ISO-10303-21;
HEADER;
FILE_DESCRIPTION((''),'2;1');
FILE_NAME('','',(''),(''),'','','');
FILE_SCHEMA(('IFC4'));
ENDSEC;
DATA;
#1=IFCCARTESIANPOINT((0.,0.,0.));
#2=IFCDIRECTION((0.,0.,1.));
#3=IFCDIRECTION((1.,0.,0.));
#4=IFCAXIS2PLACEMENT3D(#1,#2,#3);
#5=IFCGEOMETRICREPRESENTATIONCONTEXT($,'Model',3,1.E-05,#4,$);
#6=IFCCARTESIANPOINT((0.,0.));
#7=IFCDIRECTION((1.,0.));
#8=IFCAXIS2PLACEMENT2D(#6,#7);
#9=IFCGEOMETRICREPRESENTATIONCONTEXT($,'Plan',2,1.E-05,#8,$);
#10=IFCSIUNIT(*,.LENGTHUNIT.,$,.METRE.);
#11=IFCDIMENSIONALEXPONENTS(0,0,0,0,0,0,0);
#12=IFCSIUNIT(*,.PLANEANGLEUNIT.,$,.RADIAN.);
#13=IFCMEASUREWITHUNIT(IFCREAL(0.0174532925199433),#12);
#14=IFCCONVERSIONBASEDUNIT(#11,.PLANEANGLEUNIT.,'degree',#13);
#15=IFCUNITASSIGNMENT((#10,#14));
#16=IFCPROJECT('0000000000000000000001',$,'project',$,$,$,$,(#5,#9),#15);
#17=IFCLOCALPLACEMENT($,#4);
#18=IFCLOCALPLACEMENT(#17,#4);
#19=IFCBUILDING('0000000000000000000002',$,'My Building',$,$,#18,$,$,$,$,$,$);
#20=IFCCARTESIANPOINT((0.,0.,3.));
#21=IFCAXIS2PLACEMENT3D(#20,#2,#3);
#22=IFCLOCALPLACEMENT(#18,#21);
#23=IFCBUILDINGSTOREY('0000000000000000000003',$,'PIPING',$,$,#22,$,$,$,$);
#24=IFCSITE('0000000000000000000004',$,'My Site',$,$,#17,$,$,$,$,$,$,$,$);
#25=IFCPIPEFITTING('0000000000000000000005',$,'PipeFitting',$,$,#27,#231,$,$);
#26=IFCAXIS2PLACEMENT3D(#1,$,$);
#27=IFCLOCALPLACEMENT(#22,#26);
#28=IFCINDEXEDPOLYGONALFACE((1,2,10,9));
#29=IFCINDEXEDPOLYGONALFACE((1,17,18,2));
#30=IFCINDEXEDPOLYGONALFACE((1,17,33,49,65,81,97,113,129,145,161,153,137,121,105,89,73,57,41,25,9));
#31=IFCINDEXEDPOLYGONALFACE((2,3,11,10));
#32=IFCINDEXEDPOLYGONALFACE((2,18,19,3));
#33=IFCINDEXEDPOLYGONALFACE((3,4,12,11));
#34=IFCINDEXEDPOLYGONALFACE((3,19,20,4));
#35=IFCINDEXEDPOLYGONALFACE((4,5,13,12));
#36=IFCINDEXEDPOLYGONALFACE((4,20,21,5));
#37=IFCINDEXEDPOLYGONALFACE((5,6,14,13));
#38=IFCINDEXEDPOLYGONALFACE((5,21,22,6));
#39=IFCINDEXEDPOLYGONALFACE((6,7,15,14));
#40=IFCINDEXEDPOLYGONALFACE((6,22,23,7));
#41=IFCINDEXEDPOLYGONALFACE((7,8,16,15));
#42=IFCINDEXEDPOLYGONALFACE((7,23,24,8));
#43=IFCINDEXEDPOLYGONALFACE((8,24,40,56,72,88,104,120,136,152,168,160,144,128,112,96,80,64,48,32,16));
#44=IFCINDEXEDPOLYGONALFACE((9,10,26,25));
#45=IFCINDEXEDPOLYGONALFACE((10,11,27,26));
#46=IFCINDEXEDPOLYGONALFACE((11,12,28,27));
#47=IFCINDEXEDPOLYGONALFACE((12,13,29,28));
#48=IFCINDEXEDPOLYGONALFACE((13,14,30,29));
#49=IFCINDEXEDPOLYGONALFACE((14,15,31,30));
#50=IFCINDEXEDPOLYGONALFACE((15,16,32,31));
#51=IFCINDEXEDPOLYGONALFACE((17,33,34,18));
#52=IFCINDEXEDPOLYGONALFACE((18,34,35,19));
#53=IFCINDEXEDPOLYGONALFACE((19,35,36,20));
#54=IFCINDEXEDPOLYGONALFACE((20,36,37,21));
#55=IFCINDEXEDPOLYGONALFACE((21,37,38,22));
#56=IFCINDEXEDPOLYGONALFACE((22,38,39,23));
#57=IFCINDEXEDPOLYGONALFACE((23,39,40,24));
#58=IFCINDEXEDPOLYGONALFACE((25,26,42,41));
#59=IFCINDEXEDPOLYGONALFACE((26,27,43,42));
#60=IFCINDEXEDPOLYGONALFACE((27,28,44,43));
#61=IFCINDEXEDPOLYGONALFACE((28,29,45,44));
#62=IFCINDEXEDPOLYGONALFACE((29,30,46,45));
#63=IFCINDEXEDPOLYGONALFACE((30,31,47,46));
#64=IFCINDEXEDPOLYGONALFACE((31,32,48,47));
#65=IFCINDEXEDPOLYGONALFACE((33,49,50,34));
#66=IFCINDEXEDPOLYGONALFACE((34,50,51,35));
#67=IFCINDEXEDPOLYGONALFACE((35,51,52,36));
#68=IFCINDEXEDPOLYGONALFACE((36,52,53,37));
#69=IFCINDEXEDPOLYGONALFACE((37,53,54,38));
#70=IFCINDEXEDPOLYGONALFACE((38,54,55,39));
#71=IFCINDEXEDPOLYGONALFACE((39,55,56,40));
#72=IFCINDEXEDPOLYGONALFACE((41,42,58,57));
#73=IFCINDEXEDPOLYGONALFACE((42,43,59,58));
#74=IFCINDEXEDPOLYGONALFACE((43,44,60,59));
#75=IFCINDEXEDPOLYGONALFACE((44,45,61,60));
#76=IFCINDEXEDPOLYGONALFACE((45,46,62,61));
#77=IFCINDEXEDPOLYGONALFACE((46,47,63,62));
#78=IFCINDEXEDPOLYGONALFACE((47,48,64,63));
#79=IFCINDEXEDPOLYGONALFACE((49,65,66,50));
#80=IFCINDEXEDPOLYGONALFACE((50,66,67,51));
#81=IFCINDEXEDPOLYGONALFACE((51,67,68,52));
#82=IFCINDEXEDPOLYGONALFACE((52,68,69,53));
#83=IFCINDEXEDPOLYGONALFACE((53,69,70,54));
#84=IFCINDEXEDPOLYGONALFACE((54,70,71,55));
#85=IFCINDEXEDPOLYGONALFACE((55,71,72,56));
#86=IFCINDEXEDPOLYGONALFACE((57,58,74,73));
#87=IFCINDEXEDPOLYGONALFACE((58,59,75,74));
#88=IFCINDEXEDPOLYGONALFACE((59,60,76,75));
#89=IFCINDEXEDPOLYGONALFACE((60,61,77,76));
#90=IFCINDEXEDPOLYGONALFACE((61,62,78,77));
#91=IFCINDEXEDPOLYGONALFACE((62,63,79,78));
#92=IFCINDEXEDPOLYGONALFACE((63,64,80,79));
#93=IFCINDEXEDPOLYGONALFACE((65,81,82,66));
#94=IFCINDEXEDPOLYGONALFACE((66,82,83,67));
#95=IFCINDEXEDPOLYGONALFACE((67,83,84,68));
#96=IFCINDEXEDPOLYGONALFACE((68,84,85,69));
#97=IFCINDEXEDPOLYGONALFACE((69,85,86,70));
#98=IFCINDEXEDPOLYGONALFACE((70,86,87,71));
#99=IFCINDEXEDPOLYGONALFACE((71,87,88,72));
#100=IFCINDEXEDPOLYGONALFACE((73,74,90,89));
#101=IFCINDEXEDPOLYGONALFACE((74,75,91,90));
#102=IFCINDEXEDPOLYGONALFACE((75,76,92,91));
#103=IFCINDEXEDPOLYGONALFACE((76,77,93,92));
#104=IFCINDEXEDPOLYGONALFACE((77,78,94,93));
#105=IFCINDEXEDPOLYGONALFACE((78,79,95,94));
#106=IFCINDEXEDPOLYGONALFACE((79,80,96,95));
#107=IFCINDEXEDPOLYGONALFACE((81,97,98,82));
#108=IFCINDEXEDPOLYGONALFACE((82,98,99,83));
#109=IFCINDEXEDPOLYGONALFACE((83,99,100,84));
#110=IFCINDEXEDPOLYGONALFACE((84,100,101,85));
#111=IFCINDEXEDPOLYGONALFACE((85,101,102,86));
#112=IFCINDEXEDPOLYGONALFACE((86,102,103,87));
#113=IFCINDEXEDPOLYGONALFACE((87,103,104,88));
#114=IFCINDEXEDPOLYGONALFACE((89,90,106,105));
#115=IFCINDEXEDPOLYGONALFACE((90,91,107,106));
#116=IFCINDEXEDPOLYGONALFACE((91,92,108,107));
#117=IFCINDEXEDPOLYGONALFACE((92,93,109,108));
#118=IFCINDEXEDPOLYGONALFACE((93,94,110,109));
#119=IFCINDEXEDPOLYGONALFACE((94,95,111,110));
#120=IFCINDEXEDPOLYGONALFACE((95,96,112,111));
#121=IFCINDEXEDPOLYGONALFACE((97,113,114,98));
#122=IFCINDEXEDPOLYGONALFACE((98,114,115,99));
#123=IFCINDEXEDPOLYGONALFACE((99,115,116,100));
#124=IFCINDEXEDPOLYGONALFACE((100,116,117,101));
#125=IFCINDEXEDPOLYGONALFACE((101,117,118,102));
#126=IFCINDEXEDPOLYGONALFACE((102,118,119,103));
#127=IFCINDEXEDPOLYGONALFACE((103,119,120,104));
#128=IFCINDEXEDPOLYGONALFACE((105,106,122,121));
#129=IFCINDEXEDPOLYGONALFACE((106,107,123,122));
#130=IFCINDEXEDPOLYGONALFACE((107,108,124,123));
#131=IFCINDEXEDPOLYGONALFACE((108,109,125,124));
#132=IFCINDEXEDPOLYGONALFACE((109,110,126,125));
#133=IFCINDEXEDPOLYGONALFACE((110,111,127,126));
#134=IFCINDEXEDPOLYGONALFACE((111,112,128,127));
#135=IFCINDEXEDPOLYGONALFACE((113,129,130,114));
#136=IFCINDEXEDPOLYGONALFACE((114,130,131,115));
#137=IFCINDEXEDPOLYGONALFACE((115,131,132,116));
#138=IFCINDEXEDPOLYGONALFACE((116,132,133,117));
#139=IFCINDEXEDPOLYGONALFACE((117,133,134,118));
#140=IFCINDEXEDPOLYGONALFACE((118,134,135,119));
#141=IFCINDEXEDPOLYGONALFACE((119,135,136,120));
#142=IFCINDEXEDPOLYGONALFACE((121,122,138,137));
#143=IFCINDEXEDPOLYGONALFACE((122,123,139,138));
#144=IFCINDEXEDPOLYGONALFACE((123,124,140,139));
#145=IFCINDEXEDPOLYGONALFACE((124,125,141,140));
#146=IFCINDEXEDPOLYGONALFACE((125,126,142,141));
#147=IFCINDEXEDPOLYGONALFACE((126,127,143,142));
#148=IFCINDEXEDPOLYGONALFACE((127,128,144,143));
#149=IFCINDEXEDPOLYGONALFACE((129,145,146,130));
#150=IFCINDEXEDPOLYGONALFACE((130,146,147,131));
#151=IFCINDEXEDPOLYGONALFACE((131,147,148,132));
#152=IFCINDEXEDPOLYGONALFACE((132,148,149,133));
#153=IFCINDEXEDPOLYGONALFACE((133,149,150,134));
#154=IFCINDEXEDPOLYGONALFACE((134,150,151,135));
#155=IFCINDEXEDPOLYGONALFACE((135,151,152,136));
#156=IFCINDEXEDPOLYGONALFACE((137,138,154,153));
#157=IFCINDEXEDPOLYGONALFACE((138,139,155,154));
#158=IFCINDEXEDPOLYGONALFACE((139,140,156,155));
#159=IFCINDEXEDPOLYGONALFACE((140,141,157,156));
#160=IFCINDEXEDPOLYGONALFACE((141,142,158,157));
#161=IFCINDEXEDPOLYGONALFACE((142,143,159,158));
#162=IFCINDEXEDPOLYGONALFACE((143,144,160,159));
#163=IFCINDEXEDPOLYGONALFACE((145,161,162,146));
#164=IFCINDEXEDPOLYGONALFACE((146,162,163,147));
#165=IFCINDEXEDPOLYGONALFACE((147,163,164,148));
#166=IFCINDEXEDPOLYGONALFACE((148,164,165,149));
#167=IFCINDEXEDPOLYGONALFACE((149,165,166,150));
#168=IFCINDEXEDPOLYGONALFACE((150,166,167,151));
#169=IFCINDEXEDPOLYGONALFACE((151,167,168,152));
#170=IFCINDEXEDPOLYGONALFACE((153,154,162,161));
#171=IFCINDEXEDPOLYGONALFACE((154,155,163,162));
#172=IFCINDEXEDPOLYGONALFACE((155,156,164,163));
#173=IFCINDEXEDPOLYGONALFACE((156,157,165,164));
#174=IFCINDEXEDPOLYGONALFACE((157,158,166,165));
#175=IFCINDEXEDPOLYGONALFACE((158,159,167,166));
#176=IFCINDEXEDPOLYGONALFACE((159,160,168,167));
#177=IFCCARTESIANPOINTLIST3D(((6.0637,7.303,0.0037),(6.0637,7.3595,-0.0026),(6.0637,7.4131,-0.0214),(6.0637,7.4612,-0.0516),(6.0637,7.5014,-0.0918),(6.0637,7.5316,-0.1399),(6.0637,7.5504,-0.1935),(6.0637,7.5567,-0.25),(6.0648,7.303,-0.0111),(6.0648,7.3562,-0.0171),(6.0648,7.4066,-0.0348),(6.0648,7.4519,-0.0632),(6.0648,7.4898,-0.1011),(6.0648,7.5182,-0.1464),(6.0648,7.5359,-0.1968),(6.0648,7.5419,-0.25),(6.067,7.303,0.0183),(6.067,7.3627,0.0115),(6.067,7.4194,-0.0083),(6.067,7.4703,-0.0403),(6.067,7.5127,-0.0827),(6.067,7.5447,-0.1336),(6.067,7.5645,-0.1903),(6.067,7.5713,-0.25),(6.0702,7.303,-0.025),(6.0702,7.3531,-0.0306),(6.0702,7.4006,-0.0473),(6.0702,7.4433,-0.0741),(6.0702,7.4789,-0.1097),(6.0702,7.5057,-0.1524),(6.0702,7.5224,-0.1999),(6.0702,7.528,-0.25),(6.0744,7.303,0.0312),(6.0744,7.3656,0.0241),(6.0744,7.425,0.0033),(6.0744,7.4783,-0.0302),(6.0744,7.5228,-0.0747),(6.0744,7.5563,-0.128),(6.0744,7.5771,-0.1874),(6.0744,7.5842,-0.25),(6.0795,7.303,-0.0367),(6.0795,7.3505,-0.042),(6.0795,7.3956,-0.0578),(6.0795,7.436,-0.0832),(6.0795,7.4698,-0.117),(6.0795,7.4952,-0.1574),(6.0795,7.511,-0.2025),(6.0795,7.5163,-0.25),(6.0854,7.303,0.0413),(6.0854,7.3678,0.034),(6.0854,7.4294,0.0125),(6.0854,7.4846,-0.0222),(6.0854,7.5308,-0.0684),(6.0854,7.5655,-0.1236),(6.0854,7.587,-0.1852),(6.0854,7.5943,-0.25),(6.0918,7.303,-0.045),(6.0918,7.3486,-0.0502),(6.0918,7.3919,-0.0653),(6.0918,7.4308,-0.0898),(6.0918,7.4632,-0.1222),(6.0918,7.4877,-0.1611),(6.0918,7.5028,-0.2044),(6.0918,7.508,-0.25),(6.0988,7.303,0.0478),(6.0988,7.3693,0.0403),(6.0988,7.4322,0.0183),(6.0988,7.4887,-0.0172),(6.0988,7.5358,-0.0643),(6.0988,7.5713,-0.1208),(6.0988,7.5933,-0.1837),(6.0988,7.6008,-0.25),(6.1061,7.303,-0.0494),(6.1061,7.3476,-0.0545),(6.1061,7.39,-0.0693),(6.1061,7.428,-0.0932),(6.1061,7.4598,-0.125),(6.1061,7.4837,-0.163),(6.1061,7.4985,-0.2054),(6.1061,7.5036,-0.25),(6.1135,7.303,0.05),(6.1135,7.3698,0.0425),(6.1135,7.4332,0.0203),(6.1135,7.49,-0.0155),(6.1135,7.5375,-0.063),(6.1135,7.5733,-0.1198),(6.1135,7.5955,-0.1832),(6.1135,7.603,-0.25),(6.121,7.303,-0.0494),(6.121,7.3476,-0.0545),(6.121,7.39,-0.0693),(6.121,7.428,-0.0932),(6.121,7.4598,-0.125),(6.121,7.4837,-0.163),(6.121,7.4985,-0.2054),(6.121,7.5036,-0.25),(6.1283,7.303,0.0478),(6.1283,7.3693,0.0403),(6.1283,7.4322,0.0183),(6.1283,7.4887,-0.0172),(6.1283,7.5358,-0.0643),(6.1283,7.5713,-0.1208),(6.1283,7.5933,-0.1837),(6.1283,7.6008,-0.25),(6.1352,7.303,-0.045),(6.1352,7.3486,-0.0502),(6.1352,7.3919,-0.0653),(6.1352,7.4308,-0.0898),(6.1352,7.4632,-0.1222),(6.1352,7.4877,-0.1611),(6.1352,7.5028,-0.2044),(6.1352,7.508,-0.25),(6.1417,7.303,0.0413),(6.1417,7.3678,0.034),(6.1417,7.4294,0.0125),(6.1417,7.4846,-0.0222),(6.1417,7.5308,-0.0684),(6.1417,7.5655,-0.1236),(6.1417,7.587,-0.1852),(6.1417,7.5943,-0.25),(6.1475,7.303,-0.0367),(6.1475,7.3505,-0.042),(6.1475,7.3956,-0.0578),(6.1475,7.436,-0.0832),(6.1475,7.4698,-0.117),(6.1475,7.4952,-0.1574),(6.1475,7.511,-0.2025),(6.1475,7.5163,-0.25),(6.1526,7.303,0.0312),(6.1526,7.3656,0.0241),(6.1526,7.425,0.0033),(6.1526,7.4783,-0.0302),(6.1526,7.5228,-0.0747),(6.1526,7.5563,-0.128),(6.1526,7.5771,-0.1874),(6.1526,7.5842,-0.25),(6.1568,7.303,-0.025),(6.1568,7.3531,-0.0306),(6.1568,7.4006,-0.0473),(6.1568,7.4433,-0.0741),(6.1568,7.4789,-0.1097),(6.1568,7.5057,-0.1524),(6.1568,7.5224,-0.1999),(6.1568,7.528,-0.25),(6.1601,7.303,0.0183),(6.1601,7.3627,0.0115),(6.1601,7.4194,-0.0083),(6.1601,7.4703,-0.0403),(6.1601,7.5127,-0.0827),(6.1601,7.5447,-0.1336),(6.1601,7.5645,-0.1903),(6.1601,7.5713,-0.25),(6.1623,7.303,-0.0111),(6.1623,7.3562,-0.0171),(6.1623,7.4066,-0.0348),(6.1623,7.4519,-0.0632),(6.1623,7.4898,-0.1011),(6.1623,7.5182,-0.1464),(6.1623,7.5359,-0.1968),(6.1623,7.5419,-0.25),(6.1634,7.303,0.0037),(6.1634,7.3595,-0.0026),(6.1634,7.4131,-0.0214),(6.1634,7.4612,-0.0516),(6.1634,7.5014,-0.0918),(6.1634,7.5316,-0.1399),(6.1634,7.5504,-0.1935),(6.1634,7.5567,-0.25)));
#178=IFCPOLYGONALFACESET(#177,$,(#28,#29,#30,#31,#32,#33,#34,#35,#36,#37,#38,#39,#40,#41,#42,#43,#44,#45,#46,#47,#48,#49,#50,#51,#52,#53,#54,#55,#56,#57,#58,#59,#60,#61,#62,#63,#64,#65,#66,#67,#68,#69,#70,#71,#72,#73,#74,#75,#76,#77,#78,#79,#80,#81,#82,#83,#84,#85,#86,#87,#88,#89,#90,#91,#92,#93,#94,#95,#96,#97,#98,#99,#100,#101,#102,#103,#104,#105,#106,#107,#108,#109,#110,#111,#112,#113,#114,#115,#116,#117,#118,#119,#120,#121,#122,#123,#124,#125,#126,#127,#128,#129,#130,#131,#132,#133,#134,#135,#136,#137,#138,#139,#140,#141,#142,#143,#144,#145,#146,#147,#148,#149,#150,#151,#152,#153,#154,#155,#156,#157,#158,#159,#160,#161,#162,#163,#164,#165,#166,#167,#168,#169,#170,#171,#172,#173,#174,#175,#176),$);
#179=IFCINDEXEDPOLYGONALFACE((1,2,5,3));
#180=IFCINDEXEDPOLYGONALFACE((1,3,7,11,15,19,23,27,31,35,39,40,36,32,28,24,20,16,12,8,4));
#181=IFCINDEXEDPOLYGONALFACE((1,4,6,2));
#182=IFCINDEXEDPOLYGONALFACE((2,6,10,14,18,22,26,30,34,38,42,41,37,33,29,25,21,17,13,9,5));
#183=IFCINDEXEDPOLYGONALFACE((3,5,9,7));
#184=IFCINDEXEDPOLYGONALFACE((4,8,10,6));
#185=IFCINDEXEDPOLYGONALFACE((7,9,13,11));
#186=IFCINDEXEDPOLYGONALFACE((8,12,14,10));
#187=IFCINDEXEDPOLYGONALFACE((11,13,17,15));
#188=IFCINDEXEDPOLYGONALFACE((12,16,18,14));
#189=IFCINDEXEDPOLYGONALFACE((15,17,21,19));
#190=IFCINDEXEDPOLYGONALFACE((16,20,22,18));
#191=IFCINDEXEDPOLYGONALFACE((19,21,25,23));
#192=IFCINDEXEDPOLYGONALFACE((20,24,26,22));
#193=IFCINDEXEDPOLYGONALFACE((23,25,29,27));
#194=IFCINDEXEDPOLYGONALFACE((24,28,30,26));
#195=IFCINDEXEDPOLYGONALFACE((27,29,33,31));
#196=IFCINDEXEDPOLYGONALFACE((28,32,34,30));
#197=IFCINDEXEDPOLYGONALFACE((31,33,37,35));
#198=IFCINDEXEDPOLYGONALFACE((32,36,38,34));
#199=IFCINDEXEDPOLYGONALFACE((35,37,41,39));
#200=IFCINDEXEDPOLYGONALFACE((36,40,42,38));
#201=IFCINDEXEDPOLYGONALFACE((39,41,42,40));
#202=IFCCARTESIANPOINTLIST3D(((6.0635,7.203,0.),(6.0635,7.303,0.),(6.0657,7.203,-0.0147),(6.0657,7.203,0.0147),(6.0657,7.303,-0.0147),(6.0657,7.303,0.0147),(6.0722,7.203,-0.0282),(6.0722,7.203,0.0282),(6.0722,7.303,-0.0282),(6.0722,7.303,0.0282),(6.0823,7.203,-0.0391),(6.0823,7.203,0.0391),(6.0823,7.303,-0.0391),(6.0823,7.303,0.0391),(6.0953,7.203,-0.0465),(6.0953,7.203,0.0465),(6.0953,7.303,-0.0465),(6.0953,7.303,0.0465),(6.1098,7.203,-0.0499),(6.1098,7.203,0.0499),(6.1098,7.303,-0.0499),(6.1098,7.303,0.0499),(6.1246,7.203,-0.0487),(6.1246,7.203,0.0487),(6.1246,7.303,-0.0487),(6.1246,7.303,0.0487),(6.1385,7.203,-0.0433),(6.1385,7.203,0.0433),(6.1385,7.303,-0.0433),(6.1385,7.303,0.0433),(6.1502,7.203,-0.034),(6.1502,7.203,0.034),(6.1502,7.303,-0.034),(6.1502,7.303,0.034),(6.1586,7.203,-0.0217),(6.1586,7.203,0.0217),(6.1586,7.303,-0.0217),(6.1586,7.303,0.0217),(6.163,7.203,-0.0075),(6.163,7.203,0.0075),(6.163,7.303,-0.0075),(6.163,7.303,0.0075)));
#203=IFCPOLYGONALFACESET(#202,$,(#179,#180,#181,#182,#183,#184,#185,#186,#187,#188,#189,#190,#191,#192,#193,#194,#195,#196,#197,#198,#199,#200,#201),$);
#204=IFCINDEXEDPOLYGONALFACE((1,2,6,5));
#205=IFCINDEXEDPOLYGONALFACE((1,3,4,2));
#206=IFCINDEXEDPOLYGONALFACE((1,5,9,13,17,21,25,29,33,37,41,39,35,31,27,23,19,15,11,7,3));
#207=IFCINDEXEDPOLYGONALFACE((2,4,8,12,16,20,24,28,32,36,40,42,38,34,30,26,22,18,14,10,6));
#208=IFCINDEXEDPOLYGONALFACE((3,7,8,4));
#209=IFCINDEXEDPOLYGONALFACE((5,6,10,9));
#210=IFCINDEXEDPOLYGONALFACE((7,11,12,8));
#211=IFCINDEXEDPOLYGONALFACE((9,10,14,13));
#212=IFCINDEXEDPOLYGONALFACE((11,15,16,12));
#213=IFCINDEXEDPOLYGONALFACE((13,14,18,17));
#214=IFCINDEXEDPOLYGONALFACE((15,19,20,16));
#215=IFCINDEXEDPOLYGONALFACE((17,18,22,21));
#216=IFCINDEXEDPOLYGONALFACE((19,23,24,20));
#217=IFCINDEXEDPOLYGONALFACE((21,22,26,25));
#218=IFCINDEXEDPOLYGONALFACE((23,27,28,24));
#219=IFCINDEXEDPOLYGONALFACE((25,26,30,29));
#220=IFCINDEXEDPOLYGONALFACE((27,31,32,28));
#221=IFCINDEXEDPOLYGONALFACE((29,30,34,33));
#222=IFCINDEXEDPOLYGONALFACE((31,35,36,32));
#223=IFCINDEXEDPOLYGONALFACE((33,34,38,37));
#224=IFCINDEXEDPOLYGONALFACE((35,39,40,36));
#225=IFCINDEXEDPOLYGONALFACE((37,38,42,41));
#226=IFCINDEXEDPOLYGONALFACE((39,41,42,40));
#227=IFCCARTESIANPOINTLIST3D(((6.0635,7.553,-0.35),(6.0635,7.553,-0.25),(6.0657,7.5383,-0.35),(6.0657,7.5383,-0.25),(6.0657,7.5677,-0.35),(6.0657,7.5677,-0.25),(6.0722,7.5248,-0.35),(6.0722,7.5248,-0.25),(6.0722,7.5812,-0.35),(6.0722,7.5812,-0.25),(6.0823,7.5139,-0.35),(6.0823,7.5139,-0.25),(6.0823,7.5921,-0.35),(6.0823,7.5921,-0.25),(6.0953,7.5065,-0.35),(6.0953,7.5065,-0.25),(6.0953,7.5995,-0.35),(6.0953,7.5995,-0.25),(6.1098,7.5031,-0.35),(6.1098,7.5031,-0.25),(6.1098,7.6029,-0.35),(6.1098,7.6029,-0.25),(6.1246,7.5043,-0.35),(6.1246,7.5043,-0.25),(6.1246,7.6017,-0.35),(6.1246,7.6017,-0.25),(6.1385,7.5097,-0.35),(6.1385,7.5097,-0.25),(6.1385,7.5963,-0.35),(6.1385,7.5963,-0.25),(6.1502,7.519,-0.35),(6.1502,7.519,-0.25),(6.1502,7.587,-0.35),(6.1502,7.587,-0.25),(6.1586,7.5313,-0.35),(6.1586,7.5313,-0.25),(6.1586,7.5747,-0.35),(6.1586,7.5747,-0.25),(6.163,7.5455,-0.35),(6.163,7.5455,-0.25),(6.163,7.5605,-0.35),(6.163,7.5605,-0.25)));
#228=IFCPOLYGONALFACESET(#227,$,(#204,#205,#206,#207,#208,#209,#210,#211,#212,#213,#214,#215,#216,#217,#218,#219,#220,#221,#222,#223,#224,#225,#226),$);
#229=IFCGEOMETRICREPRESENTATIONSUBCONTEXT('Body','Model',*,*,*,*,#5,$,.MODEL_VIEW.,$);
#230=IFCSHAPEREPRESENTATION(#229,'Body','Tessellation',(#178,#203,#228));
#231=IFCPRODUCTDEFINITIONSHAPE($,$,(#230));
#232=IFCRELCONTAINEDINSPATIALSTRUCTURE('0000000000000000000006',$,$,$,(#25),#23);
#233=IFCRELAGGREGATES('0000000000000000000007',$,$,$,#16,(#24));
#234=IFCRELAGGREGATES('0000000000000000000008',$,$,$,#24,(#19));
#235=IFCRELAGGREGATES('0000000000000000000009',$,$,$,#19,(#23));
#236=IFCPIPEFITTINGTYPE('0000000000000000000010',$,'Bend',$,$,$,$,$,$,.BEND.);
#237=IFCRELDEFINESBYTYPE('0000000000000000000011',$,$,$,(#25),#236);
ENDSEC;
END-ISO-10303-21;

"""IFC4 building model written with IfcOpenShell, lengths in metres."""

from ifc_helpers import new_model, entity, si_unit, converted_unit, frame, origin_with_axes, origin_2d_with_axis, place, context, subcontext, project, spatial, circle, extrude, source, transform, mapped, type_object, type_shapes, element, save


model = new_model("IFC4")

# Units and contexts
model_context = context("Model", 3, precision=1e-05, world=origin_with_axes())
plan_context = context("Plan", 2, precision=1e-05, world=origin_2d_with_axis())
body_context = subcontext(model_context, "Body", "Model", "MODEL_VIEW")
ifc_project = project(units=[si_unit("LENGTHUNIT", "METRE"), converted_unit("PLANEANGLEUNIT", "degree", entity("IfcReal", 0.0174532925199433), si_unit("PLANEANGLEUNIT", "RADIAN"), dimensions=[0, 0, 0, 0, 0, 0, 0])], contexts=[model_context, plan_context])

# Site, building, storey
site_placement = place(None, origin_with_axes())
site = spatial("IfcSite", under=ifc_project, at=site_placement, Name="My Site")
building_placement = place(site_placement, origin_with_axes())
building = spatial("IfcBuilding", under=site, at=building_placement, Name="My Building")
storey_placement = place(building_placement, frame((0.0, 0.0, 3.0), z_axis=(0.0, 0.0, 1.0), x_axis=(1.0, 0.0, 0.0)))
storey = spatial("IfcBuildingStorey", under=building, at=storey_placement, Name="PIPING")

# Shared definitions
pipe_fitting_type = type_object("IfcPipeFittingType", Name="Bend", PredefinedType="BEND")
shared_shape = source(origin_with_axes(), body_context, "Body", "SolidModel", [
    entity("IfcSweptDiskSolid", entity("IfcIndexedPolyCurve", entity("IfcCartesianPointList3D", [[0.0, 0.0, -0.1], [0.0, 0.0732, -0.2768], [0.0, 0.25, -0.35]]), [entity("IfcArcIndex", [1, 2, 3])]), 0.05),
    extrude(circle(Radius=0.05), origin_with_axes(), (0.0, 0.0, -1.0), 0.1),
    extrude(circle(Radius=0.05), frame((0.0, 0.25, -0.35), z_axis=(0.0, 1.0, 0.0), x_axis=(1.0, 0.0, 0.0)), (0.0, 0.0, 1.0), 0.1),
])
type_shapes(pipe_fitting_type, [shared_shape])

# Pipe fitting
for number, where, z_axis, x_axis, name in (
    (1, (6.1135, 7.203, 0.0), (0.0, -1.0, 0.0), (-1.0, 0.0, 0.0), "PipeFitting"),
):
    element("IfcPipeFitting", number, at=place(storey_placement, frame(where, z_axis=z_axis, x_axis=x_axis)), inside=storey, type_object=pipe_fitting_type, Name=name, context=body_context, shape_type="MappedRepresentation", body=[
        mapped(shared_shape, transform((0.0, 0.0, 0.0), x_axis=(1.0, 0.0, 0.0), y_axis=(0.0, 1.0, 0.0), z_axis=(0.0, 0.0, 1.0), scale=1.0)),
    ])

save(model, "model.ifc")
